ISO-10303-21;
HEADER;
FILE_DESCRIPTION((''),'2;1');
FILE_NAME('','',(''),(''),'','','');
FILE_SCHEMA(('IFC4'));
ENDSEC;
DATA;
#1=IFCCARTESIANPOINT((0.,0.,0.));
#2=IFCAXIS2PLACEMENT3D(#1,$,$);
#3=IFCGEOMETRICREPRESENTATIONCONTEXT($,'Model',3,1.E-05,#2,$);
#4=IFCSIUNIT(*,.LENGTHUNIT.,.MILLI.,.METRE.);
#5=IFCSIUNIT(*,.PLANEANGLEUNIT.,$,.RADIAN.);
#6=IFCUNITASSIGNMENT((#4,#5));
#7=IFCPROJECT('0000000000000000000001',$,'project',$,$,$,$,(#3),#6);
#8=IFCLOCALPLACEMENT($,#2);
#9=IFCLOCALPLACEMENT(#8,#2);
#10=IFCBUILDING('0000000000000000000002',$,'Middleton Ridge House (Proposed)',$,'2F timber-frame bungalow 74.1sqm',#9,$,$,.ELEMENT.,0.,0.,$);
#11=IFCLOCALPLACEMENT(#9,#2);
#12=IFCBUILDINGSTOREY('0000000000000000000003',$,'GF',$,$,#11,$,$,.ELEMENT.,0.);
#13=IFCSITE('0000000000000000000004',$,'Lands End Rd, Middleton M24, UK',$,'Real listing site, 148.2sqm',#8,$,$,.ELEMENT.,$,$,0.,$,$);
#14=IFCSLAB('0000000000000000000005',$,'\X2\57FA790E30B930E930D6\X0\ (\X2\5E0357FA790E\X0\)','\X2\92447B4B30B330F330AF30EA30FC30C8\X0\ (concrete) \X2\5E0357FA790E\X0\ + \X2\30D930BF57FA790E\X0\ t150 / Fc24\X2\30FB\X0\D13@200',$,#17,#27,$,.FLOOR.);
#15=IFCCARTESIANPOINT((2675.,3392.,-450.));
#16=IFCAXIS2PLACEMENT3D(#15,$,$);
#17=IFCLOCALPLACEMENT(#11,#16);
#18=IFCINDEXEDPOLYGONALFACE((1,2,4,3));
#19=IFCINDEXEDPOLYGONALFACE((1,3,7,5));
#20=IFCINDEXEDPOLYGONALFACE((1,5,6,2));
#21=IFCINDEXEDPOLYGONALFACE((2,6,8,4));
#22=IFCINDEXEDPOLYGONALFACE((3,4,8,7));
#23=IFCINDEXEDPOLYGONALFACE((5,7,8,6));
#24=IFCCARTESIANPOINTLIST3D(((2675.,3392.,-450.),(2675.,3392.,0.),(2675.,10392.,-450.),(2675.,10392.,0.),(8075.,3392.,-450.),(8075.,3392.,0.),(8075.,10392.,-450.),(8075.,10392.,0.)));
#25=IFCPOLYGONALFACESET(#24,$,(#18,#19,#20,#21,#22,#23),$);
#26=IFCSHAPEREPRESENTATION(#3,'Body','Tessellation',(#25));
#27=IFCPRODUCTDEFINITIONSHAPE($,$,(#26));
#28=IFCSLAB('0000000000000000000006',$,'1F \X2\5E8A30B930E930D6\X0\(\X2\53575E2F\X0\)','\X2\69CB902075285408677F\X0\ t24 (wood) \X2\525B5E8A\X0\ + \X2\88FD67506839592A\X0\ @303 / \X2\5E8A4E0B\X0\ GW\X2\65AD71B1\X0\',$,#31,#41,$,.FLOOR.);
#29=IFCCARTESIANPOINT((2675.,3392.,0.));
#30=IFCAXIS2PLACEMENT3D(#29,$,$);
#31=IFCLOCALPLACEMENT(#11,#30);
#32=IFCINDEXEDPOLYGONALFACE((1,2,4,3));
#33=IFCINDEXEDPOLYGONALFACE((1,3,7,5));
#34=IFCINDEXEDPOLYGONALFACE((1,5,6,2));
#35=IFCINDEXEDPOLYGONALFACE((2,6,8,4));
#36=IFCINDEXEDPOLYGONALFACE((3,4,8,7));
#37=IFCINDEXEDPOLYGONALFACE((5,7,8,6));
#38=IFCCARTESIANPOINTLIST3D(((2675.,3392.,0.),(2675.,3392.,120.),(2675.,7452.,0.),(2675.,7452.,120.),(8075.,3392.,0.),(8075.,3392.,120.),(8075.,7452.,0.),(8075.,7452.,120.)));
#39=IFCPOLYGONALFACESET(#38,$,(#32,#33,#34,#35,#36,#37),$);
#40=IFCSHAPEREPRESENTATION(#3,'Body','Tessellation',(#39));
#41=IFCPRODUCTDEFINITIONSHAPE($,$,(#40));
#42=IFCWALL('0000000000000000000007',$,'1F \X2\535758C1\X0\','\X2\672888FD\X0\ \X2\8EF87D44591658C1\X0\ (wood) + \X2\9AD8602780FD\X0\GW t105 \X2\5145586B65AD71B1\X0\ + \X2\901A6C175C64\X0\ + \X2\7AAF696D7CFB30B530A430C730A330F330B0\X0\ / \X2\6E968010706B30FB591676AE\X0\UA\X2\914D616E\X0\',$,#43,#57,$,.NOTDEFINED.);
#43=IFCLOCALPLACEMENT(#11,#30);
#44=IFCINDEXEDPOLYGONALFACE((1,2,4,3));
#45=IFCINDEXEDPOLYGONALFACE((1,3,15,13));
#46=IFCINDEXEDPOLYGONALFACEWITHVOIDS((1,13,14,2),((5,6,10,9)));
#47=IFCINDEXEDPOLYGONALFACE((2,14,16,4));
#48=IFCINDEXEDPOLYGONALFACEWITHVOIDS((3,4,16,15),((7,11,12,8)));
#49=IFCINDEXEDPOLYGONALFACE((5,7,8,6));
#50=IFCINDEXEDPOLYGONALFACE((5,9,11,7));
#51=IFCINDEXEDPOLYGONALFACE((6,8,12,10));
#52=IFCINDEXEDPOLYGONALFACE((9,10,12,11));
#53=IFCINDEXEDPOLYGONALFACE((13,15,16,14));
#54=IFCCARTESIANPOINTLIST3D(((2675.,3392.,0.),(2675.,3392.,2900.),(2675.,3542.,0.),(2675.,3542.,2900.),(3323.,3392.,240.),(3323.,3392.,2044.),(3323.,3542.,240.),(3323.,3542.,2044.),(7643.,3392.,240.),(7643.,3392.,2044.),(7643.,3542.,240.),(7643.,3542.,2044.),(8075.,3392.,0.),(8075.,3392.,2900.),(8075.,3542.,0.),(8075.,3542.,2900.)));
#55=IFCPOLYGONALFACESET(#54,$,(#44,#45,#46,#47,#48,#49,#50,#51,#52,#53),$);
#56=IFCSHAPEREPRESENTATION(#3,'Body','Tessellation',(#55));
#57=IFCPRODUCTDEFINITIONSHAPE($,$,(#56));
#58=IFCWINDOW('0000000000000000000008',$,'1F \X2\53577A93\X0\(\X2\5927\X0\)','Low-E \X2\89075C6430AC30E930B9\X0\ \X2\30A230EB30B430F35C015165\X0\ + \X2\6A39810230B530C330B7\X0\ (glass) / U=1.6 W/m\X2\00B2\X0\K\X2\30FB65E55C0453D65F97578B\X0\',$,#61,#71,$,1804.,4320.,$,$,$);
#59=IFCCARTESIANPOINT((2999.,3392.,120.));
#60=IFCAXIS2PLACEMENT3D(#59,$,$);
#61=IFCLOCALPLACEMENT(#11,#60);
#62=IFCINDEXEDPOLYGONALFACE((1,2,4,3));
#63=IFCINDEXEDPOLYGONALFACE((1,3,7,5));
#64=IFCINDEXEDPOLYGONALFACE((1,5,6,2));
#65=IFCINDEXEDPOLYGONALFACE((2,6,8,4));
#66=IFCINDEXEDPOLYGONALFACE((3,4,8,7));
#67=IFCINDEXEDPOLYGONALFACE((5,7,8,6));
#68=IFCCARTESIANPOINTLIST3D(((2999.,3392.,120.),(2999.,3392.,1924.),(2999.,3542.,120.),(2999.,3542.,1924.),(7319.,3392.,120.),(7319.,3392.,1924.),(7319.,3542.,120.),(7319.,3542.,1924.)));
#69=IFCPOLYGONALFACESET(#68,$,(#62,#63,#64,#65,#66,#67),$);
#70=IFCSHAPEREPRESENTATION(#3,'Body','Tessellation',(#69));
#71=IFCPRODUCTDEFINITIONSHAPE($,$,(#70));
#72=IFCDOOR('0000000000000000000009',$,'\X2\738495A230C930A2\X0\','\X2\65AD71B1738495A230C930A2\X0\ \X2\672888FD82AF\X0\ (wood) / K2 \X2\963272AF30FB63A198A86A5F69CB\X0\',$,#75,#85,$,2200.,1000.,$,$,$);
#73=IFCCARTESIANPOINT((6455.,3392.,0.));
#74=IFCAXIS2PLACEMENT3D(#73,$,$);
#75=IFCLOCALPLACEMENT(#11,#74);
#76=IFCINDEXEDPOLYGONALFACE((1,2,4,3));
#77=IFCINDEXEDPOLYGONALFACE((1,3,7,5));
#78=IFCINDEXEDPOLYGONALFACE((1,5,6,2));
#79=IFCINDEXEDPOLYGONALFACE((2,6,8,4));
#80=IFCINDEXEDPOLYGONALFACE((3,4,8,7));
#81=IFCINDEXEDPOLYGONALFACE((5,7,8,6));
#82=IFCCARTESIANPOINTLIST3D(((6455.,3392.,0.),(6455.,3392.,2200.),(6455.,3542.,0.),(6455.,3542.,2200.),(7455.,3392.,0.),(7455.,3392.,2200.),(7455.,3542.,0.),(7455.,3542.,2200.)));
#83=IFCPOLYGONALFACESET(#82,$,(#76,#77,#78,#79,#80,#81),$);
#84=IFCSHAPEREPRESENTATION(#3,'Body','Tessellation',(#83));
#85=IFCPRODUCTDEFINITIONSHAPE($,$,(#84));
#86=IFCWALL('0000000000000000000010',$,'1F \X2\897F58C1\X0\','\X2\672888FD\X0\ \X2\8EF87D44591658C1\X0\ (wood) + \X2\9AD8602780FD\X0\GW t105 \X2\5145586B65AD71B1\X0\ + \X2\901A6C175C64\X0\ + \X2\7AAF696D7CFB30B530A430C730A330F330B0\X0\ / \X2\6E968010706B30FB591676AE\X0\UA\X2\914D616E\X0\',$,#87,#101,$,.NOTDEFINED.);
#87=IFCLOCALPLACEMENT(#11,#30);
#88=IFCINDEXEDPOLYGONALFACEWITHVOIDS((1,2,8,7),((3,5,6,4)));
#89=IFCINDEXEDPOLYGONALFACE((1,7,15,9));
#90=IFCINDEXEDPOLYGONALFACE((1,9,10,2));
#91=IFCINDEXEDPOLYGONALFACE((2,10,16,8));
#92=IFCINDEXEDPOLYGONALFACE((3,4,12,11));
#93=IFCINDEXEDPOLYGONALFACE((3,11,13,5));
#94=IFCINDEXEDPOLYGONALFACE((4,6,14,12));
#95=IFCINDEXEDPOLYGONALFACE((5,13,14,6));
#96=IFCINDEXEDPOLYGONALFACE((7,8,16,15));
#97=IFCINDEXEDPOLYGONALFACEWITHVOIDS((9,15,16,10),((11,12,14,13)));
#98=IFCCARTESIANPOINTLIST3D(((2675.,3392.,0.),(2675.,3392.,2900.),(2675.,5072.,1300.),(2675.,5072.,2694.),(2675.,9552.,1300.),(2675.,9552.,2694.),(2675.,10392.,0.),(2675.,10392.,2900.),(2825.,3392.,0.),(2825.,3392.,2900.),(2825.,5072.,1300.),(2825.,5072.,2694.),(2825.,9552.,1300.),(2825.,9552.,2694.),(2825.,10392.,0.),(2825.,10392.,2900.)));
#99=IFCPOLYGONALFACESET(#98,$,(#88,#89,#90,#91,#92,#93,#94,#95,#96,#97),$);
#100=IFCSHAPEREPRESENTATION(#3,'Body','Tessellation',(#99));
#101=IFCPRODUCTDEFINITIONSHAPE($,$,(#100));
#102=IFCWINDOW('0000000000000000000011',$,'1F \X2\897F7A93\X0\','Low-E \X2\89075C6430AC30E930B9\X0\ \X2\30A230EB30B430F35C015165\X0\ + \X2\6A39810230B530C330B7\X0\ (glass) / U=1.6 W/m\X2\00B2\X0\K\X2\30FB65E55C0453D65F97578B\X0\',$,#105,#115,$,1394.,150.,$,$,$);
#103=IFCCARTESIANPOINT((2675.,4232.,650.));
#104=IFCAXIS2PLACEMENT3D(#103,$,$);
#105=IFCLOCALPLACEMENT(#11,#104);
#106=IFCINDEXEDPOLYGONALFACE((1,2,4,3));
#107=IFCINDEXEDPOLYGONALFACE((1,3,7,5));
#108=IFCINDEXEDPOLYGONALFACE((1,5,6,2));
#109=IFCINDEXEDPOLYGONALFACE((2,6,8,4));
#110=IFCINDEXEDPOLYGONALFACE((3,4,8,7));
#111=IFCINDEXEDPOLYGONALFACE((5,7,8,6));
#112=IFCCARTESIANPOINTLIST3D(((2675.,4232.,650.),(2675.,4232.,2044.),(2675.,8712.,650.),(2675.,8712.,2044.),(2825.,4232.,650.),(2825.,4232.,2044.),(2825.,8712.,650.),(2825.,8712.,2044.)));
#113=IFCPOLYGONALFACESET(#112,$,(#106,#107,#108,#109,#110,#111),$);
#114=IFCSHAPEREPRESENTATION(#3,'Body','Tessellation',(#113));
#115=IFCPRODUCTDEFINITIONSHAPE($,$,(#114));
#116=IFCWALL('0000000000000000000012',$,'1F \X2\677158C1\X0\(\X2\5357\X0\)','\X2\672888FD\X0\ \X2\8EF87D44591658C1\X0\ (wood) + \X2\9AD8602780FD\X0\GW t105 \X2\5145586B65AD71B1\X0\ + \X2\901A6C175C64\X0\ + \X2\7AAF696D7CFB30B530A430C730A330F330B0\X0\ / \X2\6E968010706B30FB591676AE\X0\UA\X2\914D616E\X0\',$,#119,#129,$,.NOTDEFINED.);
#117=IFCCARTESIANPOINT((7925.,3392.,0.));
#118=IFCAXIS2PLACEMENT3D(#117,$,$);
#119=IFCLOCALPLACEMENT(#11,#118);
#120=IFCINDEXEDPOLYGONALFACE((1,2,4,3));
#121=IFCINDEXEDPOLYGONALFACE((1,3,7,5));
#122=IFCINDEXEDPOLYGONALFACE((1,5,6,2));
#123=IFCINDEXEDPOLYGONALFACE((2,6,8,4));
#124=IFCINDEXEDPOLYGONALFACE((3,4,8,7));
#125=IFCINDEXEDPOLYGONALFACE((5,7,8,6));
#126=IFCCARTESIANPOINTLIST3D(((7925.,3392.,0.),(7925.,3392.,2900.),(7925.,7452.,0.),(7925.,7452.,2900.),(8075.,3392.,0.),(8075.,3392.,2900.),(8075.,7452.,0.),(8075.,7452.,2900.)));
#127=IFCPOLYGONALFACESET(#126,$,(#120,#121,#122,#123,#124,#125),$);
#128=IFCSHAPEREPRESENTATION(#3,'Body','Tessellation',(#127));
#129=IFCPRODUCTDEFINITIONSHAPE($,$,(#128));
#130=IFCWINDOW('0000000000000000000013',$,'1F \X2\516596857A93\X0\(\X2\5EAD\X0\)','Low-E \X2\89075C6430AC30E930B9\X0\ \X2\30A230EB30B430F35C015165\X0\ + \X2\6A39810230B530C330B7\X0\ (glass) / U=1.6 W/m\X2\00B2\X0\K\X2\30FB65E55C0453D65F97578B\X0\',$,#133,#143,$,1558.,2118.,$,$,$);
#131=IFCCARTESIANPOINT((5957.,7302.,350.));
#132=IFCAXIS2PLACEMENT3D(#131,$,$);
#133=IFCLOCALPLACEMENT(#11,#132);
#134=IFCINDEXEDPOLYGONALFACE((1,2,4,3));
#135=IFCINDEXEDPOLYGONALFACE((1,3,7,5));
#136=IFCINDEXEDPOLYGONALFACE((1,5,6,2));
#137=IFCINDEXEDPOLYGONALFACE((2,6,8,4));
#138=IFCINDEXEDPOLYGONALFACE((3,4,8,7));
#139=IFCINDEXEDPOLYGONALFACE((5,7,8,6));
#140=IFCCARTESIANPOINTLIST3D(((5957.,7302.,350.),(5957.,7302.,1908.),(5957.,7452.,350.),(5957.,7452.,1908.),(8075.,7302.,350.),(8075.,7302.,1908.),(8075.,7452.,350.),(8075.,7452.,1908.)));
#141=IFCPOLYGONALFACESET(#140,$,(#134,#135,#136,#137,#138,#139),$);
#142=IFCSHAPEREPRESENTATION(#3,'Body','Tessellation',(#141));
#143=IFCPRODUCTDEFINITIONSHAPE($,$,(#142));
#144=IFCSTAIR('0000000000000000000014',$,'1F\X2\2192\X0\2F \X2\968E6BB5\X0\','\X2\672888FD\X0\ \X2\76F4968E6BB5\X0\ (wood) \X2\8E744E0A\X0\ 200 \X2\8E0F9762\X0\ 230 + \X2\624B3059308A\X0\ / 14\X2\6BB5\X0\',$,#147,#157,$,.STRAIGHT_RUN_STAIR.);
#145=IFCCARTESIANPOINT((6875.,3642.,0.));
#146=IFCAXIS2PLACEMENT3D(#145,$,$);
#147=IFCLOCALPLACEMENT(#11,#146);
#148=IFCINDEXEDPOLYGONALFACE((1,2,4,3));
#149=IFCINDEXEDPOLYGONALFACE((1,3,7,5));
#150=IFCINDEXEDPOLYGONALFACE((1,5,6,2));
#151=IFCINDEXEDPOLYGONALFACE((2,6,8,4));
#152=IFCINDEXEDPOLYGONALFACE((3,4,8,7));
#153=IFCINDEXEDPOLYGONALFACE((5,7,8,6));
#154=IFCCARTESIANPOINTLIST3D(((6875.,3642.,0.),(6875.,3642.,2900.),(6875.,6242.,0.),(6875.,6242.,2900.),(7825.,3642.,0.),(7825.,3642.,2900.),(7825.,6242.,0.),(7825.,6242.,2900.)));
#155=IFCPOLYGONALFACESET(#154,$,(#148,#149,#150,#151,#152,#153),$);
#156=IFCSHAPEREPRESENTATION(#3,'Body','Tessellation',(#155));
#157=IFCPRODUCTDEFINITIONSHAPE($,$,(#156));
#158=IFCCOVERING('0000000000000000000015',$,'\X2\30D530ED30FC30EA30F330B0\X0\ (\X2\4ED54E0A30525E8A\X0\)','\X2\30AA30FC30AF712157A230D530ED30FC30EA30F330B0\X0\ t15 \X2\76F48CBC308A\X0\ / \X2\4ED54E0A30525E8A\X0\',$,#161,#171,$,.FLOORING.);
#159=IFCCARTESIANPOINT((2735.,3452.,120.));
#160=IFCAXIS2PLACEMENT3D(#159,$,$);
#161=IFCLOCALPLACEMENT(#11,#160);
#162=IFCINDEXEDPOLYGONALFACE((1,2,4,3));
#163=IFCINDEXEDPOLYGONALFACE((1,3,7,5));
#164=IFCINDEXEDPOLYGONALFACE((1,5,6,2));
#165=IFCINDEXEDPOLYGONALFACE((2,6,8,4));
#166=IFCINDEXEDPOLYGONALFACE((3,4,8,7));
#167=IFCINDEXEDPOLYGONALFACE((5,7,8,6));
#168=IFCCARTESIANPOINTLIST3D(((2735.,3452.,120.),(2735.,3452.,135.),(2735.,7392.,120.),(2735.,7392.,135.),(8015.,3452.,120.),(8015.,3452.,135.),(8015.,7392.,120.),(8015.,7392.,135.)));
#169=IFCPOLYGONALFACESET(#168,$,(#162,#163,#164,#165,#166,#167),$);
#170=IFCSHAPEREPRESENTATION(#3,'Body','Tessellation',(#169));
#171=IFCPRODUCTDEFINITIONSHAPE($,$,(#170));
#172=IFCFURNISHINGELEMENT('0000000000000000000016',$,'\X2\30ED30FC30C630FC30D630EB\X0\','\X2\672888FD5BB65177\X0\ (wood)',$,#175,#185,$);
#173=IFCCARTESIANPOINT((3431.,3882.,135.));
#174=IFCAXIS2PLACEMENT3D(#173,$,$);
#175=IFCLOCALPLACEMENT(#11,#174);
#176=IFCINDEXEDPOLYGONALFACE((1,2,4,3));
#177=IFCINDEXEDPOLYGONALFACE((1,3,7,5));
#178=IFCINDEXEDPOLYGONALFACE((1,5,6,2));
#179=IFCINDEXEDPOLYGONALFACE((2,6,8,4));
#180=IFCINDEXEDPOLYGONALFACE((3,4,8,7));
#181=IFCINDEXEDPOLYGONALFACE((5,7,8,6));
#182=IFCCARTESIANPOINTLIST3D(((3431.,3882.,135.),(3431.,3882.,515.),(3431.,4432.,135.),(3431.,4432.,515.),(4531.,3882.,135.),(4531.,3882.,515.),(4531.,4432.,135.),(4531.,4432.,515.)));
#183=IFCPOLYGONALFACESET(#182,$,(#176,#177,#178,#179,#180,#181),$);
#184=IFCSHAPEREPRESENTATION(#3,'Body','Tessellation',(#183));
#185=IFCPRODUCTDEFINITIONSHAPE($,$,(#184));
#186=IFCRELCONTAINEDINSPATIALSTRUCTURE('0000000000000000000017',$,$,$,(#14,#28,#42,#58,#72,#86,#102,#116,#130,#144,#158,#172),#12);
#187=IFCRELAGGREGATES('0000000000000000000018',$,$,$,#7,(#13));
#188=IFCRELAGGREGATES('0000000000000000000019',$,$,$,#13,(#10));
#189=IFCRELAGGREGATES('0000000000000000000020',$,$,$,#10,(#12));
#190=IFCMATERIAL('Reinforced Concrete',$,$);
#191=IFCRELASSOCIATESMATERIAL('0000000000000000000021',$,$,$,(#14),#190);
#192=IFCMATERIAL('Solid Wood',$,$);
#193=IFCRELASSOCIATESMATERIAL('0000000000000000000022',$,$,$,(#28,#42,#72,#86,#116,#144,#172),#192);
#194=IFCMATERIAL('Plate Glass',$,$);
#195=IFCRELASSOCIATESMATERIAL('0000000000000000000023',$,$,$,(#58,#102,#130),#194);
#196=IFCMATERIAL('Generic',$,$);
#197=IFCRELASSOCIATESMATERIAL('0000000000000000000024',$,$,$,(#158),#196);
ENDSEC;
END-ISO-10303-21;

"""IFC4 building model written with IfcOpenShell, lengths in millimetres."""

from ifc_helpers import new_model, si_unit, frame, frame_2d, origin, place, context, project, spatial, rectangle, extrude, material, element, fill, save


model = new_model("IFC4")

# Units and contexts
model_context = context("Model", 3, precision=1e-05, world=origin())
ifc_project = project(units=[si_unit("LENGTHUNIT", "METRE", prefix="MILLI"), si_unit("PLANEANGLEUNIT", "RADIAN")], contexts=[model_context])

# Site, building, storey
site_placement = place(None, origin())
site = spatial("IfcSite", under=ifc_project, at=site_placement, Name="Lands End Rd, Middleton M24, UK", ObjectType="Real listing site, 148.2sqm", CompositionType="ELEMENT", RefElevation=0.0)
building_placement = place(site_placement, origin())
building = spatial("IfcBuilding", under=site, at=building_placement, Name="Middleton Ridge House (Proposed)", ObjectType="2F timber-frame bungalow 74.1sqm", CompositionType="ELEMENT", ElevationOfRefHeight=0.0, ElevationOfTerrain=0.0)
storey_placement = place(building_placement, origin())
storey = spatial("IfcBuildingStorey", under=building, at=storey_placement, Name="GF", CompositionType="ELEMENT", Elevation=0.0)

# Slabs
ifc_material_1 = material(Name="Reinforced Concrete")
slab_1_placement = place(storey_placement, frame((2675.0, 3392.0, -450.0)))
element("IfcSlab", 1, at=slab_1_placement, inside=storey, material=ifc_material_1, Name="基礎スラブ (布基礎)", Description="鉄筋コンクリート (concrete) 布基礎 + ベタ基礎 t150 / Fc24・D13@200", PredefinedType="FLOOR", context=model_context, shape_type="SweptSolid", body=[
    extrude(rectangle(XDim=5400.0, YDim=7000.0, at=frame_2d((2700.0, 3500.0))), frame((2675.0, 3392.0, -450.0)), (0.0, 0.0, 1.0), 450.0),
])
ifc_material_2 = material(Name="Solid Wood")
slab_2_placement = place(storey_placement, frame((2675.0, 3392.0, 0.0)))
element("IfcSlab", 2, at=slab_2_placement, inside=storey, material=ifc_material_2, Name="1F 床スラブ(南帯)", Description="構造用合板 t24 (wood) 剛床 + 製材根太 @303 / 床下 GW断熱", PredefinedType="FLOOR", context=model_context, shape_type="SweptSolid", body=[
    extrude(rectangle(XDim=5400.0, YDim=4060.0, at=frame_2d((2700.0, 2030.0))), frame((2675.0, 3392.0, 0.0)), (0.0, 0.0, 1.0), 120.0),
])

# Wall, openings, window, door
wall_1_placement = place(storey_placement, frame((2675.0, 3392.0, 0.0)))
wall_1 = element("IfcWall", 3, at=wall_1_placement, inside=storey, material=ifc_material_2, Name="1F 南壁", Description="木製 軸組外壁 (wood) + 高性能GW t105 充填断熱 + 通気層 + 窯業系サイディング / 準耐火・外皮UA配慮", PredefinedType="NOTDEFINED", context=model_context, shape_type="SweptSolid", body=[
    extrude(rectangle(XDim=5400.0, YDim=150.0, at=frame_2d((2700.0, 75.0))), frame((2675.0, 3392.0, 0.0)), (0.0, 0.0, 1.0), 2900.0),
])
opening_1_placement = place(storey_placement, frame((2999.0, 3392.0, 120.0)))
opening_1 = element("IfcOpeningElement", 4, at=opening_1_placement, cuts=wall_1, PredefinedType="NOTDEFINED", context=model_context, shape_type="SweptSolid", body=[
    extrude(rectangle(XDim=4320.0, YDim=150.0, at=frame_2d((2160.0, 75.0))), frame((2999.0, 3392.0, 120.0)), (0.0, 0.0, 1.0), 1804.0),
])
opening_2_placement = place(storey_placement, frame((6455.0, 3392.0, 0.0)))
opening_2 = element("IfcOpeningElement", 5, at=opening_2_placement, cuts=wall_1, PredefinedType="NOTDEFINED", context=model_context, shape_type="SweptSolid", body=[
    extrude(rectangle(XDim=1000.0, YDim=150.0, at=frame_2d((500.0, 75.0))), frame((6455.0, 3392.0, 0.0)), (0.0, 0.0, 1.0), 2200.0),
])
ifc_material_3 = material(Name="Plate Glass")
window_1_placement = place(storey_placement, frame((2999.0, 3392.0, 120.0)))
window_1 = element("IfcWindow", 6, at=window_1_placement, inside=storey, material=ifc_material_3, Name="1F 南窓(大)", Description="Low-E 複層ガラス アルゴン封入 + 樹脂サッシ (glass) / U=1.6 W/m²K・日射取得型", OverallHeight=1804.0, OverallWidth=4320.0, context=model_context, shape_type="SweptSolid", body=[
    extrude(rectangle(XDim=4320.0, YDim=150.0, at=frame_2d((2160.0, 75.0))), frame((2999.0, 3392.0, 120.0)), (0.0, 0.0, 1.0), 1804.0),
])
fill(opening_1, window_1)
door_1_placement = place(storey_placement, frame((6455.0, 3392.0, 0.0)))
door_1 = element("IfcDoor", 7, at=door_1_placement, inside=storey, material=ifc_material_2, Name="玄関ドア", Description="断熱玄関ドア 木製芯 (wood) / K2 防犯・採風機構", OverallHeight=2200.0, OverallWidth=1000.0, context=model_context, shape_type="SweptSolid", body=[
    extrude(rectangle(XDim=1000.0, YDim=150.0, at=frame_2d((500.0, 75.0))), frame((6455.0, 3392.0, 0.0)), (0.0, 0.0, 1.0), 2200.0),
])
fill(opening_2, door_1)

# Walls, openings, windows
wall_2_placement = place(storey_placement, frame((2675.0, 3392.0, 0.0)))
wall_2 = element("IfcWall", 8, at=wall_2_placement, inside=storey, material=ifc_material_2, Name="1F 西壁", Description="木製 軸組外壁 (wood) + 高性能GW t105 充填断熱 + 通気層 + 窯業系サイディング / 準耐火・外皮UA配慮", PredefinedType="NOTDEFINED", context=model_context, shape_type="SweptSolid", body=[
    extrude(rectangle(XDim=150.0, YDim=7000.0, at=frame_2d((75.0, 3500.0))), frame((2675.0, 3392.0, 0.0)), (0.0, 0.0, 1.0), 2900.0),
])
opening_3_placement = place(storey_placement, frame((2675.0, 4232.0, 650.0)))
opening_3 = element("IfcOpeningElement", 9, at=opening_3_placement, cuts=wall_2, PredefinedType="NOTDEFINED", context=model_context, shape_type="SweptSolid", body=[
    extrude(rectangle(XDim=150.0, YDim=4480.0, at=frame_2d((75.0, 2240.0))), frame((2675.0, 4232.0, 650.0)), (0.0, 0.0, 1.0), 1394.0),
])
window_2_placement = place(storey_placement, frame((2675.0, 4232.0, 650.0)))
window_2 = element("IfcWindow", 10, at=window_2_placement, inside=storey, material=ifc_material_3, Name="1F 西窓", Description="Low-E 複層ガラス アルゴン封入 + 樹脂サッシ (glass) / U=1.6 W/m²K・日射取得型", OverallHeight=1394.0, OverallWidth=150.0, context=model_context, shape_type="SweptSolid", body=[
    extrude(rectangle(XDim=150.0, YDim=4480.0, at=frame_2d((75.0, 2240.0))), frame((2675.0, 4232.0, 650.0)), (0.0, 0.0, 1.0), 1394.0),
])
fill(opening_3, window_2)
wall_3_placement = place(storey_placement, frame((7925.0, 3392.0, 0.0)))
wall_3 = element("IfcWall", 11, at=wall_3_placement, inside=storey, material=ifc_material_2, Name="1F 東壁(南)", Description="木製 軸組外壁 (wood) + 高性能GW t105 充填断熱 + 通気層 + 窯業系サイディング / 準耐火・外皮UA配慮", PredefinedType="NOTDEFINED", context=model_context, shape_type="SweptSolid", body=[
    extrude(rectangle(XDim=150.0, YDim=4060.0, at=frame_2d((75.0, 2030.0))), frame((7925.0, 3392.0, 0.0)), (0.0, 0.0, 1.0), 2900.0),
])
opening_4_placement = place(storey_placement, frame((5957.0, 7302.0, 350.0)))
opening_4 = element("IfcOpeningElement", 12, at=opening_4_placement, cuts=wall_3, PredefinedType="NOTDEFINED", context=model_context, shape_type="SweptSolid", body=[
    extrude(rectangle(XDim=2118.0, YDim=150.0, at=frame_2d((1059.0, 75.0))), frame((5957.0, 7302.0, 350.0)), (0.0, 0.0, 1.0), 1558.0),
])
window_3_placement = place(storey_placement, frame((5957.0, 7302.0, 350.0)))
window_3 = element("IfcWindow", 13, at=window_3_placement, inside=storey, material=ifc_material_3, Name="1F 入隅窓(庭)", Description="Low-E 複層ガラス アルゴン封入 + 樹脂サッシ (glass) / U=1.6 W/m²K・日射取得型", OverallHeight=1558.0, OverallWidth=2118.0, context=model_context, shape_type="SweptSolid", body=[
    extrude(rectangle(XDim=2118.0, YDim=150.0, at=frame_2d((1059.0, 75.0))), frame((5957.0, 7302.0, 350.0)), (0.0, 0.0, 1.0), 1558.0),
])
fill(opening_4, window_3)

# Stair
stair_placement = place(storey_placement, frame((6875.0, 3642.0, 0.0)))
element("IfcStair", 14, at=stair_placement, inside=storey, material=ifc_material_2, Name="1F→2F 階段", Description="木製 直階段 (wood) 蹴上 200 踏面 230 + 手すり / 14段", PredefinedType="STRAIGHT_RUN_STAIR", context=model_context, shape_type="SweptSolid", body=[
    extrude(rectangle(XDim=950.0, YDim=2600.0, at=frame_2d((475.0, 1300.0))), frame((6875.0, 3642.0, 0.0)), (0.0, 0.0, 1.0), 2900.0),
])

# Covering
ifc_material_4 = material(Name="Generic")
covering_placement = place(storey_placement, frame((2735.0, 3452.0, 120.0)))
element("IfcCovering", 15, at=covering_placement, inside=storey, material=ifc_material_4, Name="フローリング (仕上げ床)", Description="オーク無垢フローリング t15 直貼り / 仕上げ床", PredefinedType="FLOORING", context=model_context, shape_type="SweptSolid", body=[
    extrude(rectangle(XDim=5280.0, YDim=3940.0, at=frame_2d((2640.0, 1970.0))), frame((2735.0, 3452.0, 120.0)), (0.0, 0.0, 1.0), 15.0),
])

# Furnishing element
furnishing_1_placement = place(storey_placement, frame((3431.0, 3882.0, 135.0)))
element("IfcFurnishingElement", 16, at=furnishing_1_placement, inside=storey, material=ifc_material_2, Name="ローテーブル", Description="木製家具 (wood)", context=model_context, shape_type="SweptSolid", body=[
    extrude(rectangle(XDim=1100.0, YDim=550.0, at=frame_2d((550.0, 275.0))), frame((3431.0, 3882.0, 135.0)), (0.0, 0.0, 1.0), 380.0),
])

save(model, "model.ifc")
